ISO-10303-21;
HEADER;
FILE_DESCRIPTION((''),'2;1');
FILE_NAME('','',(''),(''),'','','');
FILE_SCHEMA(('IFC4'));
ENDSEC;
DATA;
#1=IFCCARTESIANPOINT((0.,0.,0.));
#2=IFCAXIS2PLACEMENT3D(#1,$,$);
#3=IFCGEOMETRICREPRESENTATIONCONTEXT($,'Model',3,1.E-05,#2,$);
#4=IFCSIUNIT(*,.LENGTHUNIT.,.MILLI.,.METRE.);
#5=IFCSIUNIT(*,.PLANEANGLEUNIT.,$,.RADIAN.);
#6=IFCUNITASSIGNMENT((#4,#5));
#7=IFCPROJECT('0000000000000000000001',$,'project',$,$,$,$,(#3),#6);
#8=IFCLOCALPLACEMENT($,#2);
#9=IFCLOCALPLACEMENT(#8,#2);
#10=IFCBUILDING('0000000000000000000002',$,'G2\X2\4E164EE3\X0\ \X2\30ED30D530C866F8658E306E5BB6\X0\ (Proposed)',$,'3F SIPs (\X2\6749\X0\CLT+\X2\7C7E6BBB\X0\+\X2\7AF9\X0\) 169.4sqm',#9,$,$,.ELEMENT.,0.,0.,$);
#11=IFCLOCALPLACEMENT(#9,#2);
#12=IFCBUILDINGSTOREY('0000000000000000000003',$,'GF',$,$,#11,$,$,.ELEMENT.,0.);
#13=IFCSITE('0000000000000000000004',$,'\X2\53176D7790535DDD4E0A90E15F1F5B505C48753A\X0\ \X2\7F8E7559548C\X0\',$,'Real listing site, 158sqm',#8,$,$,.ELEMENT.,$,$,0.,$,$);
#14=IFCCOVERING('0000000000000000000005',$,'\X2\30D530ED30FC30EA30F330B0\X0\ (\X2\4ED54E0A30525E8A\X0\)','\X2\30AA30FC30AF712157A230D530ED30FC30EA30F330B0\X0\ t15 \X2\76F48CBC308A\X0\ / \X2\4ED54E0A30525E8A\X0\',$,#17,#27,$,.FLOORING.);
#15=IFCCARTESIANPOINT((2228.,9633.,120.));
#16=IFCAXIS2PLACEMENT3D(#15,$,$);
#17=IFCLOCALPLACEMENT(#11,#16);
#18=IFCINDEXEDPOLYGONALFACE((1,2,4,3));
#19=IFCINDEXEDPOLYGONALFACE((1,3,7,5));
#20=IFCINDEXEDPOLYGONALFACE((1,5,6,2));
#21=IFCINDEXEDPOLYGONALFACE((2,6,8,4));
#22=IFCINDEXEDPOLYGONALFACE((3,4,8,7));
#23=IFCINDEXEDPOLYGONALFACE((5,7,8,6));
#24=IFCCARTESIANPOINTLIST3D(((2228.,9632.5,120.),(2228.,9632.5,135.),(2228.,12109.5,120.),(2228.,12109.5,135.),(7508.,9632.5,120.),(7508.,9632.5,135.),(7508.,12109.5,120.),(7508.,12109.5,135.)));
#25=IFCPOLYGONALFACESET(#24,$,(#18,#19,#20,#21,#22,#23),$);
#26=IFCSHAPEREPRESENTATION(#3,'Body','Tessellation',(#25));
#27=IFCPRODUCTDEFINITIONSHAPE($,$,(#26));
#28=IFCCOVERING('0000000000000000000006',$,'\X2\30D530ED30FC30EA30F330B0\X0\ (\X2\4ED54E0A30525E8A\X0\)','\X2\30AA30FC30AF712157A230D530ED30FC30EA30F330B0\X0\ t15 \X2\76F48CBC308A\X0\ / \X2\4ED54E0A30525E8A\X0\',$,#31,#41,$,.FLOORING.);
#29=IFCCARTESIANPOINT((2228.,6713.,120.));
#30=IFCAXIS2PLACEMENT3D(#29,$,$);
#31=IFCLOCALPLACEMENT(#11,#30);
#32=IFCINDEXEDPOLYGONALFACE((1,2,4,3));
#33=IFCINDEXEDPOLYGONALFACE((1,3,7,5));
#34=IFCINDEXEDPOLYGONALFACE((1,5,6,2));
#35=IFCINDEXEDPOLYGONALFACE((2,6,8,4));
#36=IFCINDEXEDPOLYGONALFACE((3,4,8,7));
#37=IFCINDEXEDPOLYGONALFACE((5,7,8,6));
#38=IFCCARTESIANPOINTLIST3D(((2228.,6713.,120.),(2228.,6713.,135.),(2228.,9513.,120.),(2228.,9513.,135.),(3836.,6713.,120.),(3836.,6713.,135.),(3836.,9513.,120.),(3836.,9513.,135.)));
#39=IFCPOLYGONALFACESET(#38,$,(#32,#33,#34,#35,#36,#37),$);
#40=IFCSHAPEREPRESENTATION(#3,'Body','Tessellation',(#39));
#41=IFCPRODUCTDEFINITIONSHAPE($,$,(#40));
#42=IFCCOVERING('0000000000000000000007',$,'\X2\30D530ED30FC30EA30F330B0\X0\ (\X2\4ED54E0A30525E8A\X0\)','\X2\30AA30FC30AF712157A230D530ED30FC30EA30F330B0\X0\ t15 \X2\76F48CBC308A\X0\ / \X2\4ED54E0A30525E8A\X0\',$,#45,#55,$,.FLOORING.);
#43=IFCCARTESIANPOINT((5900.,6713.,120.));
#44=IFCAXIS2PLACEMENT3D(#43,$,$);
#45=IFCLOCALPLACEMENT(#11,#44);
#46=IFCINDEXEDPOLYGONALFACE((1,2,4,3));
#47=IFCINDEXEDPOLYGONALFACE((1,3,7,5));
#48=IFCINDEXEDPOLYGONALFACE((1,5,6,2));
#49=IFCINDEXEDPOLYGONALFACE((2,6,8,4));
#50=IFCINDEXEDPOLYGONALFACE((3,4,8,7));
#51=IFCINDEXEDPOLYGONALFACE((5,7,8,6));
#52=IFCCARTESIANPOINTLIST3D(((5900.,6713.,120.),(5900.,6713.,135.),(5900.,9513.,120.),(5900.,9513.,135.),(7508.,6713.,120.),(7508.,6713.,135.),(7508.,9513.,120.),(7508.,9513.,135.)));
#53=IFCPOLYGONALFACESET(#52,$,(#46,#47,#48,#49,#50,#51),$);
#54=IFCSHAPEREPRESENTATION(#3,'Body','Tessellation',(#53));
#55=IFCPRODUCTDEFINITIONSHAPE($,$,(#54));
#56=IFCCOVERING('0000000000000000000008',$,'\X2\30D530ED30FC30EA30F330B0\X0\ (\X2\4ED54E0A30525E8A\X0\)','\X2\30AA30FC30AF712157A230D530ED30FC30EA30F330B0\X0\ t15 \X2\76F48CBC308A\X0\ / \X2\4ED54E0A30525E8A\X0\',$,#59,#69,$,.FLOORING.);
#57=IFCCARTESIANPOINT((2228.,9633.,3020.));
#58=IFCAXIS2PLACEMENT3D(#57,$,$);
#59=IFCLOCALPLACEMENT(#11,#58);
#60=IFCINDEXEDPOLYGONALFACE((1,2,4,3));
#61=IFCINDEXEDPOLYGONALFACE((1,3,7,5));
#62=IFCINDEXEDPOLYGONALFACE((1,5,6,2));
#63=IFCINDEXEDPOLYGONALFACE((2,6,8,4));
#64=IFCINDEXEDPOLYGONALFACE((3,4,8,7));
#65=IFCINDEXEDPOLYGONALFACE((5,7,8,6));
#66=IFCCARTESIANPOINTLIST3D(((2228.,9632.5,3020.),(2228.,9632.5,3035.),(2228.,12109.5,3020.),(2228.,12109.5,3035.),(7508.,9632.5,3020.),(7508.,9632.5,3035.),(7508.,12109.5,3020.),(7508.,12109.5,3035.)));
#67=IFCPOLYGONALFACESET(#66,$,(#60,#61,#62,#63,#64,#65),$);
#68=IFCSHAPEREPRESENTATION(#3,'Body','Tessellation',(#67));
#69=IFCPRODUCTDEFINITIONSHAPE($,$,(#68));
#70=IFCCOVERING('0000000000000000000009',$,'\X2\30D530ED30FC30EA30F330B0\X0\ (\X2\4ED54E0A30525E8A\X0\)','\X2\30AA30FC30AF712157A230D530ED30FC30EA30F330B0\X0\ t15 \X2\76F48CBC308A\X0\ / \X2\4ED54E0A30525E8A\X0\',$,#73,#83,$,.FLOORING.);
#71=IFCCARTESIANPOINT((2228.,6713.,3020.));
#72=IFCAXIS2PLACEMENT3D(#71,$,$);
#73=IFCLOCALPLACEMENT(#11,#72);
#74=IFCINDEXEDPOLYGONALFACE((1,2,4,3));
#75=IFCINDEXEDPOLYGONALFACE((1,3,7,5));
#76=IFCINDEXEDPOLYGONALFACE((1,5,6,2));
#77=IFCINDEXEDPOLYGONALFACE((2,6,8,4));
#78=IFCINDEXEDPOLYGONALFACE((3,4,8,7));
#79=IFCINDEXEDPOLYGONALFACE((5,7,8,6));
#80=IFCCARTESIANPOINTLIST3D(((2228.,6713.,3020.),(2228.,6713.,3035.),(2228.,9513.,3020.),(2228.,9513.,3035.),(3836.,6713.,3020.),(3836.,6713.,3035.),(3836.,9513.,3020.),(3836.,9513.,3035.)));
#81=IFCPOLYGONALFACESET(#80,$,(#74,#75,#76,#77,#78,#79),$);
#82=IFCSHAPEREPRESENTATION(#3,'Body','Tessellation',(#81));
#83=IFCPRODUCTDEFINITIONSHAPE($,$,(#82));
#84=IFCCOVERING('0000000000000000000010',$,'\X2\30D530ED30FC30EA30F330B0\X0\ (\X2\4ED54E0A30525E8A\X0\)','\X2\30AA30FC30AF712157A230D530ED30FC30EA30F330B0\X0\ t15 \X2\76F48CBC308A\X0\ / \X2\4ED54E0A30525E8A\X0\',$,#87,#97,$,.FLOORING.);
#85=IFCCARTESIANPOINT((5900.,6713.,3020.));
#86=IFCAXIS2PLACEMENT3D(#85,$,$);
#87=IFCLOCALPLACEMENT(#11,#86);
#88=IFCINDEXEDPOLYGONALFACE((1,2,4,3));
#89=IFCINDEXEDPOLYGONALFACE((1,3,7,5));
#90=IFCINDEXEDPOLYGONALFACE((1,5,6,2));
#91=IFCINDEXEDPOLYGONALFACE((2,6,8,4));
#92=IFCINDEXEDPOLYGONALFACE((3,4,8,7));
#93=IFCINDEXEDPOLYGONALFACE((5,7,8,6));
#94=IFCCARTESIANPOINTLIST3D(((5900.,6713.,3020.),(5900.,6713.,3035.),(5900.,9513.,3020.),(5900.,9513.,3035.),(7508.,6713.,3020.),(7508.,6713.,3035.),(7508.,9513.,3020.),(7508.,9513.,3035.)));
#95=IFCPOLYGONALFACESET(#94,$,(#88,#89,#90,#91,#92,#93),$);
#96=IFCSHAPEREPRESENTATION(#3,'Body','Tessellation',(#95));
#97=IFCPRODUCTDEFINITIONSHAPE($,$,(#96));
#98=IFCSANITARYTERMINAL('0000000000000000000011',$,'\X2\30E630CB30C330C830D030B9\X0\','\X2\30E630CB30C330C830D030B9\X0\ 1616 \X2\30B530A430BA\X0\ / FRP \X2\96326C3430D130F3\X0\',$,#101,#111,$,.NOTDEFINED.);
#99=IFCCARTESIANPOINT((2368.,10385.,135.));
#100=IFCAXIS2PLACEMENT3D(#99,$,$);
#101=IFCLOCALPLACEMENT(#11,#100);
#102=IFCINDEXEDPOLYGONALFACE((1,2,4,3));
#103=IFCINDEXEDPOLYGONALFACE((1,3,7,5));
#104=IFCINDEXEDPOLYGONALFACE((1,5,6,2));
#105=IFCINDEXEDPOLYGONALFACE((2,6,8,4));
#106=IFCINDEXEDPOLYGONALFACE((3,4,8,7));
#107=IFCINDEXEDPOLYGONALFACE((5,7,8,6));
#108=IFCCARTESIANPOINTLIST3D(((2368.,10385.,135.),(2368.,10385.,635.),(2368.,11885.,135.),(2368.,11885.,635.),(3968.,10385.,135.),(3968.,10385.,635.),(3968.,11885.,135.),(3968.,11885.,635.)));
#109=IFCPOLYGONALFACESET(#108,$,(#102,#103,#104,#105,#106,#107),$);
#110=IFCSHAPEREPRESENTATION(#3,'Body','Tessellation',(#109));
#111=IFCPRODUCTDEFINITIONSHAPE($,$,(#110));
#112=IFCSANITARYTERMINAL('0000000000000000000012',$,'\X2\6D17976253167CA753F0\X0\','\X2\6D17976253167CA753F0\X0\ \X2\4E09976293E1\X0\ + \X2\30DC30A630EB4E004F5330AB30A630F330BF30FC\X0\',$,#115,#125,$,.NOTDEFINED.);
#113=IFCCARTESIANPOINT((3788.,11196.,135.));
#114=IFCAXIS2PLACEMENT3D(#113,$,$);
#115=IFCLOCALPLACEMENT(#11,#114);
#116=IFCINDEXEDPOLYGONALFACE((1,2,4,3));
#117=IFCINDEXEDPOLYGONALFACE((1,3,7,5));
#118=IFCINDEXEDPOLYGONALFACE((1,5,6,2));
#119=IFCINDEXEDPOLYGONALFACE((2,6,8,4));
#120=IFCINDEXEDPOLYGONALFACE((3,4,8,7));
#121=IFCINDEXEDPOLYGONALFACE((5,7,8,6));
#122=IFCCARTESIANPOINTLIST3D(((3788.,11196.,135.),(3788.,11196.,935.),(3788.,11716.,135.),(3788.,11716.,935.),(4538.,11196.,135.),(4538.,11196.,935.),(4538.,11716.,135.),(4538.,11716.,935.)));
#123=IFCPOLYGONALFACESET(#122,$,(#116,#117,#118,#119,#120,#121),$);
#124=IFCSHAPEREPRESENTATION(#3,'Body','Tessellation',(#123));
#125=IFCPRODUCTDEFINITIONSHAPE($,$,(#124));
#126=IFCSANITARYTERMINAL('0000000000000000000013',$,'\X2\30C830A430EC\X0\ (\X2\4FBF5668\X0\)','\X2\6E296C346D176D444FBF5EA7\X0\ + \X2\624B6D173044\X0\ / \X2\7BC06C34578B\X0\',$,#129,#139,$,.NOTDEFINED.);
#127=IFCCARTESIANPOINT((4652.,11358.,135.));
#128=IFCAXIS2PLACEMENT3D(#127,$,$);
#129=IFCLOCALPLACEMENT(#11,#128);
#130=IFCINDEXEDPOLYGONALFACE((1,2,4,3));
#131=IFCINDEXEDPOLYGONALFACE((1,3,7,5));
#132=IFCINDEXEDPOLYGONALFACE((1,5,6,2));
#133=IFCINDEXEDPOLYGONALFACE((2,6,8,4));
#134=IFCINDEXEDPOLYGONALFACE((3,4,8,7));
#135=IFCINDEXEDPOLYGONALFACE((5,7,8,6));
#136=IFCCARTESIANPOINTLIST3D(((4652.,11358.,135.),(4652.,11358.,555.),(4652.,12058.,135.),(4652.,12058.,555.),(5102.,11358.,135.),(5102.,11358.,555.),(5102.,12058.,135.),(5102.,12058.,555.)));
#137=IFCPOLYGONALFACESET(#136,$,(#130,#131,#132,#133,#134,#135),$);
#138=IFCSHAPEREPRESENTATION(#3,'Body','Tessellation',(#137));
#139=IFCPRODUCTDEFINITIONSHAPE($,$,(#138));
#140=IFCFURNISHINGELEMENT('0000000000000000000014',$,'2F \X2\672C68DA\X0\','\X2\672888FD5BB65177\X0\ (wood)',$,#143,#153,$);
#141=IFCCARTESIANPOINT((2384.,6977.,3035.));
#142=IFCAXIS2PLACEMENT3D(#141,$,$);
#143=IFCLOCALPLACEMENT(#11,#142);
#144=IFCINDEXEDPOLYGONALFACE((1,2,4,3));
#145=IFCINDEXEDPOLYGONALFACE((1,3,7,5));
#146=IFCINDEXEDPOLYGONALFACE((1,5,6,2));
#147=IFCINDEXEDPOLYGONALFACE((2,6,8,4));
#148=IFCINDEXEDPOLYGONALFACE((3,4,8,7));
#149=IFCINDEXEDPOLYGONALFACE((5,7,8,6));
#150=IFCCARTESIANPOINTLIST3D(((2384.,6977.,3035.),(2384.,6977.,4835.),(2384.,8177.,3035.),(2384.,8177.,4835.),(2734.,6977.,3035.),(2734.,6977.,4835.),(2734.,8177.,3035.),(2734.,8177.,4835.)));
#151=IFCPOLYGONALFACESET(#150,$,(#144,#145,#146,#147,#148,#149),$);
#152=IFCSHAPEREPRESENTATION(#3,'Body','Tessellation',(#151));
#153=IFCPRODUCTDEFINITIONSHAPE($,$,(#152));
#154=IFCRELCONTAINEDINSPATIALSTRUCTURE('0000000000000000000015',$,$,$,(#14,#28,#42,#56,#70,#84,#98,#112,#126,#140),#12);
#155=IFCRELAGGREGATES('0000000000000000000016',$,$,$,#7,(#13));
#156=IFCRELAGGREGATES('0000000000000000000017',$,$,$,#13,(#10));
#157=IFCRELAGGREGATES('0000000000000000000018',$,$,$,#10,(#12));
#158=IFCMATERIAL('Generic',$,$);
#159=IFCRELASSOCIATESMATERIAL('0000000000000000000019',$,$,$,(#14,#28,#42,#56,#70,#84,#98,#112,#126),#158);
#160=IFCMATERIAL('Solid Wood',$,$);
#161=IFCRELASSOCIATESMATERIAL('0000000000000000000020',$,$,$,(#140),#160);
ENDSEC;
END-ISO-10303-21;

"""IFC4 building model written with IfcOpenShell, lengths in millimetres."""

from ifc_helpers import new_model, si_unit, frame, frame_2d, origin, place, context, project, spatial, rectangle, extrude, material, element, save


model = new_model("IFC4")

# Units and contexts
model_context = context("Model", 3, precision=1e-05, world=origin())
ifc_project = project(units=[si_unit("LENGTHUNIT", "METRE", prefix="MILLI"), si_unit("PLANEANGLEUNIT", "RADIAN")], contexts=[model_context])

# Site, building, storey
site_placement = place(None, origin())
site = spatial("IfcSite", under=ifc_project, at=site_placement, Name="北海道川上郡弟子屈町 美留和", ObjectType="Real listing site, 158sqm", CompositionType="ELEMENT", RefElevation=0.0)
building_placement = place(site_placement, origin())
building = spatial("IfcBuilding", under=site, at=building_placement, Name="G2世代 ロフト書斎の家 (Proposed)", ObjectType="3F SIPs (杉CLT+籾殻+竹) 169.4sqm", CompositionType="ELEMENT", ElevationOfRefHeight=0.0, ElevationOfTerrain=0.0)
storey_placement = place(building_placement, origin())
storey = spatial("IfcBuildingStorey", under=building, at=storey_placement, Name="GF", CompositionType="ELEMENT", Elevation=0.0)

# Shared definitions
ifc_material_1 = material(Name="Solid Wood")

# Coverings
ifc_material_2 = material(Name="Generic")
covering_1_placement = place(storey_placement, frame((2228.0, 9633.0, 120.0)))
element("IfcCovering", 1, at=covering_1_placement, inside=storey, material=ifc_material_2, Name="フローリング (仕上げ床)", Description="オーク無垢フローリング t15 直貼り / 仕上げ床", PredefinedType="FLOORING", context=model_context, shape_type="SweptSolid", body=[
    extrude(rectangle(XDim=5280.0, YDim=2477.0, at=frame_2d((2640.0, 1238.0))), frame((2228.0, 9633.0, 120.0)), (0.0, 0.0, 1.0), 15.0),
])
covering_2_placement = place(storey_placement, frame((2228.0, 6713.0, 120.0)))
element("IfcCovering", 2, at=covering_2_placement, inside=storey, material=ifc_material_2, Name="フローリング (仕上げ床)", Description="オーク無垢フローリング t15 直貼り / 仕上げ床", PredefinedType="FLOORING", context=model_context, shape_type="SweptSolid", body=[
    extrude(rectangle(XDim=1608.0, YDim=2800.0, at=frame_2d((804.0, 1400.0))), frame((2228.0, 6713.0, 120.0)), (0.0, 0.0, 1.0), 15.0),
])
covering_3_placement = place(storey_placement, frame((5900.0, 6713.0, 120.0)))
element("IfcCovering", 3, at=covering_3_placement, inside=storey, material=ifc_material_2, Name="フローリング (仕上げ床)", Description="オーク無垢フローリング t15 直貼り / 仕上げ床", PredefinedType="FLOORING", context=model_context, shape_type="SweptSolid", body=[
    extrude(rectangle(XDim=1608.0, YDim=2800.0, at=frame_2d((804.0, 1400.0))), frame((5900.0, 6713.0, 120.0)), (0.0, 0.0, 1.0), 15.0),
])
covering_4_placement = place(storey_placement, frame((2228.0, 9633.0, 3020.0)))
element("IfcCovering", 4, at=covering_4_placement, inside=storey, material=ifc_material_2, Name="フローリング (仕上げ床)", Description="オーク無垢フローリング t15 直貼り / 仕上げ床", PredefinedType="FLOORING", context=model_context, shape_type="SweptSolid", body=[
    extrude(rectangle(XDim=5280.0, YDim=2477.0, at=frame_2d((2640.0, 1238.0))), frame((2228.0, 9633.0, 3020.0)), (0.0, 0.0, 1.0), 15.0),
])
covering_5_placement = place(storey_placement, frame((2228.0, 6713.0, 3020.0)))
element("IfcCovering", 5, at=covering_5_placement, inside=storey, material=ifc_material_2, Name="フローリング (仕上げ床)", Description="オーク無垢フローリング t15 直貼り / 仕上げ床", PredefinedType="FLOORING", context=model_context, shape_type="SweptSolid", body=[
    extrude(rectangle(XDim=1608.0, YDim=2800.0, at=frame_2d((804.0, 1400.0))), frame((2228.0, 6713.0, 3020.0)), (0.0, 0.0, 1.0), 15.0),
])
covering_6_placement = place(storey_placement, frame((5900.0, 6713.0, 3020.0)))
element("IfcCovering", 6, at=covering_6_placement, inside=storey, material=ifc_material_2, Name="フローリング (仕上げ床)", Description="オーク無垢フローリング t15 直貼り / 仕上げ床", PredefinedType="FLOORING", context=model_context, shape_type="SweptSolid", body=[
    extrude(rectangle(XDim=1608.0, YDim=2800.0, at=frame_2d((804.0, 1400.0))), frame((5900.0, 6713.0, 3020.0)), (0.0, 0.0, 1.0), 15.0),
])

# Sanitary terminals
sanitary_terminal_1_placement = place(storey_placement, frame((2368.0, 10385.0, 135.0)))
element("IfcSanitaryTerminal", 7, at=sanitary_terminal_1_placement, inside=storey, material=ifc_material_2, Name="ユニットバス", Description="ユニットバス 1616 サイズ / FRP 防水パン", PredefinedType="NOTDEFINED", context=model_context, shape_type="SweptSolid", body=[
    extrude(rectangle(XDim=1600.0, YDim=1500.0, at=frame_2d((800.0, 750.0))), frame((2368.0, 10385.0, 135.0)), (0.0, 0.0, 1.0), 500.0),
])
sanitary_terminal_2_placement = place(storey_placement, frame((3788.0, 11196.0, 135.0)))
element("IfcSanitaryTerminal", 8, at=sanitary_terminal_2_placement, inside=storey, material=ifc_material_2, Name="洗面化粧台", Description="洗面化粧台 三面鏡 + ボウル一体カウンター", PredefinedType="NOTDEFINED", context=model_context, shape_type="SweptSolid", body=[
    extrude(rectangle(XDim=750.0, YDim=520.0, at=frame_2d((375.0, 260.0))), frame((3788.0, 11196.0, 135.0)), (0.0, 0.0, 1.0), 800.0),
])
sanitary_terminal_3_placement = place(storey_placement, frame((4652.0, 11358.0, 135.0)))
element("IfcSanitaryTerminal", 9, at=sanitary_terminal_3_placement, inside=storey, material=ifc_material_2, Name="トイレ (便器)", Description="温水洗浄便座 + 手洗い / 節水型", PredefinedType="NOTDEFINED", context=model_context, shape_type="SweptSolid", body=[
    extrude(rectangle(XDim=450.0, YDim=700.0, at=frame_2d((225.0, 350.0))), frame((4652.0, 11358.0, 135.0)), (0.0, 0.0, 1.0), 420.0),
])

# Furnishing element
furnishing_placement = place(storey_placement, frame((2384.0, 6977.0, 3035.0)))
element("IfcFurnishingElement", 10, at=furnishing_placement, inside=storey, material=ifc_material_1, Name="2F 本棚", Description="木製家具 (wood)", context=model_context, shape_type="SweptSolid", body=[
    extrude(rectangle(XDim=350.0, YDim=1200.0, at=frame_2d((175.0, 600.0))), frame((2384.0, 6977.0, 3035.0)), (0.0, 0.0, 1.0), 1800.0),
])

save(model, "model.ifc")
